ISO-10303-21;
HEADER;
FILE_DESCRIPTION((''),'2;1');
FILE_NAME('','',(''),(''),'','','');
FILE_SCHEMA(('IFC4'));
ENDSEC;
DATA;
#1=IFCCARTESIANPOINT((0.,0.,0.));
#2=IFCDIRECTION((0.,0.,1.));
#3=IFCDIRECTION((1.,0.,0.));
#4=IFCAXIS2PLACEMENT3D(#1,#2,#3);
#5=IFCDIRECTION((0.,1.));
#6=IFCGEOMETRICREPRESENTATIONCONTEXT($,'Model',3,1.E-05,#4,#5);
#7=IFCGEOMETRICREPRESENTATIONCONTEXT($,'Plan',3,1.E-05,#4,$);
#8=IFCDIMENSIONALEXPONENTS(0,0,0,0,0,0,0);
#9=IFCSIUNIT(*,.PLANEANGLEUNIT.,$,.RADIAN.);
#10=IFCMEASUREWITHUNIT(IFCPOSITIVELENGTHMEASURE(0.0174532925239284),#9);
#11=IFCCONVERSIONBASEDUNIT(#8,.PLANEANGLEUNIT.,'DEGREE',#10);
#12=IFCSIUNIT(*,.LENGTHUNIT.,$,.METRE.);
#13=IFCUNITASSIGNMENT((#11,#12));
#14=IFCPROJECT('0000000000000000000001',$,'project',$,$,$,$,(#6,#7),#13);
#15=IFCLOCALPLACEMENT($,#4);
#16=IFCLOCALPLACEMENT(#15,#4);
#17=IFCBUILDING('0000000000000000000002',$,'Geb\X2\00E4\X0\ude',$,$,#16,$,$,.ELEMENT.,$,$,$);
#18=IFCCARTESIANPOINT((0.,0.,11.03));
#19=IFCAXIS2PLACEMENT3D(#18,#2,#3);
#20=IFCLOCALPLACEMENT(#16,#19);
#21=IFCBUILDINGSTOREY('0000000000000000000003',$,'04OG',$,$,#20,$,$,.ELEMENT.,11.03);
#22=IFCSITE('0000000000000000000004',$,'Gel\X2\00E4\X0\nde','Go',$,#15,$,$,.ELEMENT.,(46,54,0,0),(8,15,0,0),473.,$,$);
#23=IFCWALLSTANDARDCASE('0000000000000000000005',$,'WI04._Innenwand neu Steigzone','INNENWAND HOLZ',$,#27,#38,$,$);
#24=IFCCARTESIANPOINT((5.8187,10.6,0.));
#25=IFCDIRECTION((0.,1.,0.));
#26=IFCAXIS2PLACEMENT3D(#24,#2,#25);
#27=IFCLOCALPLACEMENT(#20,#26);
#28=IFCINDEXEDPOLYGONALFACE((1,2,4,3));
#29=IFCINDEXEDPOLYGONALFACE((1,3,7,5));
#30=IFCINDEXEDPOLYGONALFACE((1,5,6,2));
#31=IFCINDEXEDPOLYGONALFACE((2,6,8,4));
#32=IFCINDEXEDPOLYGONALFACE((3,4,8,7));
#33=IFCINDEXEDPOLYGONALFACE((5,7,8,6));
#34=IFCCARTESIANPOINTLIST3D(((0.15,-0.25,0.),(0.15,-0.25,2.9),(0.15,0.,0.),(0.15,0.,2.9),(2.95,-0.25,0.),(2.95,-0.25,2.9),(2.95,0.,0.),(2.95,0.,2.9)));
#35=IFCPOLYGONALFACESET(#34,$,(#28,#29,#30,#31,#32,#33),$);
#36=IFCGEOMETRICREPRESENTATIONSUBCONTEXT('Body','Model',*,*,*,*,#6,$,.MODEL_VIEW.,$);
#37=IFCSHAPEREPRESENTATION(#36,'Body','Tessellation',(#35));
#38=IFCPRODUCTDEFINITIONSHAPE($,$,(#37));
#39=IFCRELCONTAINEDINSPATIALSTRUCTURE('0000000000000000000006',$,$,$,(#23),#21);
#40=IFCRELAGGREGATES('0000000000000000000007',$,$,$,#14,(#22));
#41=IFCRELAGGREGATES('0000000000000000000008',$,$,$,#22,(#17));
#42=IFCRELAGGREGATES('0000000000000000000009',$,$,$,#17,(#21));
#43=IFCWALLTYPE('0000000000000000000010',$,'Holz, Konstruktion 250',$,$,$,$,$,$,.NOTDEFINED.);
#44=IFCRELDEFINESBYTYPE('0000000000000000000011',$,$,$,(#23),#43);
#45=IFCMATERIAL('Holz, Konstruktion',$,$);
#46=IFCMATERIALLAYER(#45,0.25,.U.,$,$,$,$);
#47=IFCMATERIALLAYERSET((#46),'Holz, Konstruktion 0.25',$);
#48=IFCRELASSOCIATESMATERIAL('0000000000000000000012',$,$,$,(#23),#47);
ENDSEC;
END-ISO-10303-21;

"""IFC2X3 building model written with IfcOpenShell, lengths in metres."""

from ifc_helpers import new_model, entity, si_unit, converted_unit, direction, frame, origin_with_axes, place, context, subcontext, project, spatial, polyline, outline, extrude, material, layer, layer_set, layer_usage, type_object, element, save


model = new_model("IFC2X3")

# Units and contexts
model_context = context("Model", 3, precision=1e-05, world=origin_with_axes(), true_north=direction((0.0, 1.0)))
plan_context = context("Plan", 3, precision=1e-05, world=origin_with_axes())
body_context = subcontext(model_context, "Body", "Model", "MODEL_VIEW")
ifc_project = project(units=[converted_unit("PLANEANGLEUNIT", "DEGREE", entity("IfcPositiveLengthMeasure", 0.0174532925239284), si_unit("PLANEANGLEUNIT", "RADIAN"), dimensions=[0, 0, 0, 0, 0, 0, 0]), si_unit("LENGTHUNIT", "METRE")], contexts=[model_context, plan_context])

# Site, building, storey
site_placement = place(None, origin_with_axes())
site = spatial("IfcSite", under=ifc_project, at=site_placement, Name="Gelände", Description="Go", CompositionType="ELEMENT", RefLatitude=(46, 54, 0, 0), RefLongitude=(8, 15, 0, 0), RefElevation=473.0)
building_placement = place(site_placement, origin_with_axes())
building = spatial("IfcBuilding", under=site, at=building_placement, Name="Gebäude", CompositionType="ELEMENT")
storey_placement = place(building_placement, frame((0.0, 0.0, 11.03), z_axis=(0.0, 0.0, 1.0), x_axis=(1.0, 0.0, 0.0)))
storey = spatial("IfcBuildingStorey", under=building, at=storey_placement, Name="04OG", CompositionType="ELEMENT", Elevation=11.03)

# Shared definitions
ifc_material_1 = material(Name="Holz, Konstruktion")

# Wall
ifc_layer_1 = layer(ifc_material_1, 0.25, ventilated="UNKNOWN")
ifc_layer_set_1 = layer_set([ifc_layer_1], Name="Holz, Konstruktion 0.25")
wall_type_1 = type_object("IfcWallType", Name="Holz, Konstruktion 250", PredefinedType="NOTDEFINED")
ifc_layer_usage_1 = layer_usage(ifc_layer_set_1, "AXIS2", "NEGATIVE", 0.0)
wall_1_placement = place(storey_placement, frame((5.8187, 10.6, 0.0), z_axis=(0.0, 0.0, 1.0), x_axis=(0.0, 1.0, 0.0)))
element("IfcWallStandardCase", 1, at=wall_1_placement, inside=storey, type_object=wall_type_1, material=ifc_layer_usage_1, Name="WI04._Innenwand neu Steigzone", Description="INNENWAND HOLZ", context=body_context, shape_type="SweptSolid", body=[
    extrude(outline(polyline([(0.15, -0.25), (2.95, -0.25), (2.95, 0.0), (0.15, 0.0), (0.15, -0.25)])), origin_with_axes(), (0.0, 0.0, 1.0), 2.9),
])

save(model, "model.ifc")
